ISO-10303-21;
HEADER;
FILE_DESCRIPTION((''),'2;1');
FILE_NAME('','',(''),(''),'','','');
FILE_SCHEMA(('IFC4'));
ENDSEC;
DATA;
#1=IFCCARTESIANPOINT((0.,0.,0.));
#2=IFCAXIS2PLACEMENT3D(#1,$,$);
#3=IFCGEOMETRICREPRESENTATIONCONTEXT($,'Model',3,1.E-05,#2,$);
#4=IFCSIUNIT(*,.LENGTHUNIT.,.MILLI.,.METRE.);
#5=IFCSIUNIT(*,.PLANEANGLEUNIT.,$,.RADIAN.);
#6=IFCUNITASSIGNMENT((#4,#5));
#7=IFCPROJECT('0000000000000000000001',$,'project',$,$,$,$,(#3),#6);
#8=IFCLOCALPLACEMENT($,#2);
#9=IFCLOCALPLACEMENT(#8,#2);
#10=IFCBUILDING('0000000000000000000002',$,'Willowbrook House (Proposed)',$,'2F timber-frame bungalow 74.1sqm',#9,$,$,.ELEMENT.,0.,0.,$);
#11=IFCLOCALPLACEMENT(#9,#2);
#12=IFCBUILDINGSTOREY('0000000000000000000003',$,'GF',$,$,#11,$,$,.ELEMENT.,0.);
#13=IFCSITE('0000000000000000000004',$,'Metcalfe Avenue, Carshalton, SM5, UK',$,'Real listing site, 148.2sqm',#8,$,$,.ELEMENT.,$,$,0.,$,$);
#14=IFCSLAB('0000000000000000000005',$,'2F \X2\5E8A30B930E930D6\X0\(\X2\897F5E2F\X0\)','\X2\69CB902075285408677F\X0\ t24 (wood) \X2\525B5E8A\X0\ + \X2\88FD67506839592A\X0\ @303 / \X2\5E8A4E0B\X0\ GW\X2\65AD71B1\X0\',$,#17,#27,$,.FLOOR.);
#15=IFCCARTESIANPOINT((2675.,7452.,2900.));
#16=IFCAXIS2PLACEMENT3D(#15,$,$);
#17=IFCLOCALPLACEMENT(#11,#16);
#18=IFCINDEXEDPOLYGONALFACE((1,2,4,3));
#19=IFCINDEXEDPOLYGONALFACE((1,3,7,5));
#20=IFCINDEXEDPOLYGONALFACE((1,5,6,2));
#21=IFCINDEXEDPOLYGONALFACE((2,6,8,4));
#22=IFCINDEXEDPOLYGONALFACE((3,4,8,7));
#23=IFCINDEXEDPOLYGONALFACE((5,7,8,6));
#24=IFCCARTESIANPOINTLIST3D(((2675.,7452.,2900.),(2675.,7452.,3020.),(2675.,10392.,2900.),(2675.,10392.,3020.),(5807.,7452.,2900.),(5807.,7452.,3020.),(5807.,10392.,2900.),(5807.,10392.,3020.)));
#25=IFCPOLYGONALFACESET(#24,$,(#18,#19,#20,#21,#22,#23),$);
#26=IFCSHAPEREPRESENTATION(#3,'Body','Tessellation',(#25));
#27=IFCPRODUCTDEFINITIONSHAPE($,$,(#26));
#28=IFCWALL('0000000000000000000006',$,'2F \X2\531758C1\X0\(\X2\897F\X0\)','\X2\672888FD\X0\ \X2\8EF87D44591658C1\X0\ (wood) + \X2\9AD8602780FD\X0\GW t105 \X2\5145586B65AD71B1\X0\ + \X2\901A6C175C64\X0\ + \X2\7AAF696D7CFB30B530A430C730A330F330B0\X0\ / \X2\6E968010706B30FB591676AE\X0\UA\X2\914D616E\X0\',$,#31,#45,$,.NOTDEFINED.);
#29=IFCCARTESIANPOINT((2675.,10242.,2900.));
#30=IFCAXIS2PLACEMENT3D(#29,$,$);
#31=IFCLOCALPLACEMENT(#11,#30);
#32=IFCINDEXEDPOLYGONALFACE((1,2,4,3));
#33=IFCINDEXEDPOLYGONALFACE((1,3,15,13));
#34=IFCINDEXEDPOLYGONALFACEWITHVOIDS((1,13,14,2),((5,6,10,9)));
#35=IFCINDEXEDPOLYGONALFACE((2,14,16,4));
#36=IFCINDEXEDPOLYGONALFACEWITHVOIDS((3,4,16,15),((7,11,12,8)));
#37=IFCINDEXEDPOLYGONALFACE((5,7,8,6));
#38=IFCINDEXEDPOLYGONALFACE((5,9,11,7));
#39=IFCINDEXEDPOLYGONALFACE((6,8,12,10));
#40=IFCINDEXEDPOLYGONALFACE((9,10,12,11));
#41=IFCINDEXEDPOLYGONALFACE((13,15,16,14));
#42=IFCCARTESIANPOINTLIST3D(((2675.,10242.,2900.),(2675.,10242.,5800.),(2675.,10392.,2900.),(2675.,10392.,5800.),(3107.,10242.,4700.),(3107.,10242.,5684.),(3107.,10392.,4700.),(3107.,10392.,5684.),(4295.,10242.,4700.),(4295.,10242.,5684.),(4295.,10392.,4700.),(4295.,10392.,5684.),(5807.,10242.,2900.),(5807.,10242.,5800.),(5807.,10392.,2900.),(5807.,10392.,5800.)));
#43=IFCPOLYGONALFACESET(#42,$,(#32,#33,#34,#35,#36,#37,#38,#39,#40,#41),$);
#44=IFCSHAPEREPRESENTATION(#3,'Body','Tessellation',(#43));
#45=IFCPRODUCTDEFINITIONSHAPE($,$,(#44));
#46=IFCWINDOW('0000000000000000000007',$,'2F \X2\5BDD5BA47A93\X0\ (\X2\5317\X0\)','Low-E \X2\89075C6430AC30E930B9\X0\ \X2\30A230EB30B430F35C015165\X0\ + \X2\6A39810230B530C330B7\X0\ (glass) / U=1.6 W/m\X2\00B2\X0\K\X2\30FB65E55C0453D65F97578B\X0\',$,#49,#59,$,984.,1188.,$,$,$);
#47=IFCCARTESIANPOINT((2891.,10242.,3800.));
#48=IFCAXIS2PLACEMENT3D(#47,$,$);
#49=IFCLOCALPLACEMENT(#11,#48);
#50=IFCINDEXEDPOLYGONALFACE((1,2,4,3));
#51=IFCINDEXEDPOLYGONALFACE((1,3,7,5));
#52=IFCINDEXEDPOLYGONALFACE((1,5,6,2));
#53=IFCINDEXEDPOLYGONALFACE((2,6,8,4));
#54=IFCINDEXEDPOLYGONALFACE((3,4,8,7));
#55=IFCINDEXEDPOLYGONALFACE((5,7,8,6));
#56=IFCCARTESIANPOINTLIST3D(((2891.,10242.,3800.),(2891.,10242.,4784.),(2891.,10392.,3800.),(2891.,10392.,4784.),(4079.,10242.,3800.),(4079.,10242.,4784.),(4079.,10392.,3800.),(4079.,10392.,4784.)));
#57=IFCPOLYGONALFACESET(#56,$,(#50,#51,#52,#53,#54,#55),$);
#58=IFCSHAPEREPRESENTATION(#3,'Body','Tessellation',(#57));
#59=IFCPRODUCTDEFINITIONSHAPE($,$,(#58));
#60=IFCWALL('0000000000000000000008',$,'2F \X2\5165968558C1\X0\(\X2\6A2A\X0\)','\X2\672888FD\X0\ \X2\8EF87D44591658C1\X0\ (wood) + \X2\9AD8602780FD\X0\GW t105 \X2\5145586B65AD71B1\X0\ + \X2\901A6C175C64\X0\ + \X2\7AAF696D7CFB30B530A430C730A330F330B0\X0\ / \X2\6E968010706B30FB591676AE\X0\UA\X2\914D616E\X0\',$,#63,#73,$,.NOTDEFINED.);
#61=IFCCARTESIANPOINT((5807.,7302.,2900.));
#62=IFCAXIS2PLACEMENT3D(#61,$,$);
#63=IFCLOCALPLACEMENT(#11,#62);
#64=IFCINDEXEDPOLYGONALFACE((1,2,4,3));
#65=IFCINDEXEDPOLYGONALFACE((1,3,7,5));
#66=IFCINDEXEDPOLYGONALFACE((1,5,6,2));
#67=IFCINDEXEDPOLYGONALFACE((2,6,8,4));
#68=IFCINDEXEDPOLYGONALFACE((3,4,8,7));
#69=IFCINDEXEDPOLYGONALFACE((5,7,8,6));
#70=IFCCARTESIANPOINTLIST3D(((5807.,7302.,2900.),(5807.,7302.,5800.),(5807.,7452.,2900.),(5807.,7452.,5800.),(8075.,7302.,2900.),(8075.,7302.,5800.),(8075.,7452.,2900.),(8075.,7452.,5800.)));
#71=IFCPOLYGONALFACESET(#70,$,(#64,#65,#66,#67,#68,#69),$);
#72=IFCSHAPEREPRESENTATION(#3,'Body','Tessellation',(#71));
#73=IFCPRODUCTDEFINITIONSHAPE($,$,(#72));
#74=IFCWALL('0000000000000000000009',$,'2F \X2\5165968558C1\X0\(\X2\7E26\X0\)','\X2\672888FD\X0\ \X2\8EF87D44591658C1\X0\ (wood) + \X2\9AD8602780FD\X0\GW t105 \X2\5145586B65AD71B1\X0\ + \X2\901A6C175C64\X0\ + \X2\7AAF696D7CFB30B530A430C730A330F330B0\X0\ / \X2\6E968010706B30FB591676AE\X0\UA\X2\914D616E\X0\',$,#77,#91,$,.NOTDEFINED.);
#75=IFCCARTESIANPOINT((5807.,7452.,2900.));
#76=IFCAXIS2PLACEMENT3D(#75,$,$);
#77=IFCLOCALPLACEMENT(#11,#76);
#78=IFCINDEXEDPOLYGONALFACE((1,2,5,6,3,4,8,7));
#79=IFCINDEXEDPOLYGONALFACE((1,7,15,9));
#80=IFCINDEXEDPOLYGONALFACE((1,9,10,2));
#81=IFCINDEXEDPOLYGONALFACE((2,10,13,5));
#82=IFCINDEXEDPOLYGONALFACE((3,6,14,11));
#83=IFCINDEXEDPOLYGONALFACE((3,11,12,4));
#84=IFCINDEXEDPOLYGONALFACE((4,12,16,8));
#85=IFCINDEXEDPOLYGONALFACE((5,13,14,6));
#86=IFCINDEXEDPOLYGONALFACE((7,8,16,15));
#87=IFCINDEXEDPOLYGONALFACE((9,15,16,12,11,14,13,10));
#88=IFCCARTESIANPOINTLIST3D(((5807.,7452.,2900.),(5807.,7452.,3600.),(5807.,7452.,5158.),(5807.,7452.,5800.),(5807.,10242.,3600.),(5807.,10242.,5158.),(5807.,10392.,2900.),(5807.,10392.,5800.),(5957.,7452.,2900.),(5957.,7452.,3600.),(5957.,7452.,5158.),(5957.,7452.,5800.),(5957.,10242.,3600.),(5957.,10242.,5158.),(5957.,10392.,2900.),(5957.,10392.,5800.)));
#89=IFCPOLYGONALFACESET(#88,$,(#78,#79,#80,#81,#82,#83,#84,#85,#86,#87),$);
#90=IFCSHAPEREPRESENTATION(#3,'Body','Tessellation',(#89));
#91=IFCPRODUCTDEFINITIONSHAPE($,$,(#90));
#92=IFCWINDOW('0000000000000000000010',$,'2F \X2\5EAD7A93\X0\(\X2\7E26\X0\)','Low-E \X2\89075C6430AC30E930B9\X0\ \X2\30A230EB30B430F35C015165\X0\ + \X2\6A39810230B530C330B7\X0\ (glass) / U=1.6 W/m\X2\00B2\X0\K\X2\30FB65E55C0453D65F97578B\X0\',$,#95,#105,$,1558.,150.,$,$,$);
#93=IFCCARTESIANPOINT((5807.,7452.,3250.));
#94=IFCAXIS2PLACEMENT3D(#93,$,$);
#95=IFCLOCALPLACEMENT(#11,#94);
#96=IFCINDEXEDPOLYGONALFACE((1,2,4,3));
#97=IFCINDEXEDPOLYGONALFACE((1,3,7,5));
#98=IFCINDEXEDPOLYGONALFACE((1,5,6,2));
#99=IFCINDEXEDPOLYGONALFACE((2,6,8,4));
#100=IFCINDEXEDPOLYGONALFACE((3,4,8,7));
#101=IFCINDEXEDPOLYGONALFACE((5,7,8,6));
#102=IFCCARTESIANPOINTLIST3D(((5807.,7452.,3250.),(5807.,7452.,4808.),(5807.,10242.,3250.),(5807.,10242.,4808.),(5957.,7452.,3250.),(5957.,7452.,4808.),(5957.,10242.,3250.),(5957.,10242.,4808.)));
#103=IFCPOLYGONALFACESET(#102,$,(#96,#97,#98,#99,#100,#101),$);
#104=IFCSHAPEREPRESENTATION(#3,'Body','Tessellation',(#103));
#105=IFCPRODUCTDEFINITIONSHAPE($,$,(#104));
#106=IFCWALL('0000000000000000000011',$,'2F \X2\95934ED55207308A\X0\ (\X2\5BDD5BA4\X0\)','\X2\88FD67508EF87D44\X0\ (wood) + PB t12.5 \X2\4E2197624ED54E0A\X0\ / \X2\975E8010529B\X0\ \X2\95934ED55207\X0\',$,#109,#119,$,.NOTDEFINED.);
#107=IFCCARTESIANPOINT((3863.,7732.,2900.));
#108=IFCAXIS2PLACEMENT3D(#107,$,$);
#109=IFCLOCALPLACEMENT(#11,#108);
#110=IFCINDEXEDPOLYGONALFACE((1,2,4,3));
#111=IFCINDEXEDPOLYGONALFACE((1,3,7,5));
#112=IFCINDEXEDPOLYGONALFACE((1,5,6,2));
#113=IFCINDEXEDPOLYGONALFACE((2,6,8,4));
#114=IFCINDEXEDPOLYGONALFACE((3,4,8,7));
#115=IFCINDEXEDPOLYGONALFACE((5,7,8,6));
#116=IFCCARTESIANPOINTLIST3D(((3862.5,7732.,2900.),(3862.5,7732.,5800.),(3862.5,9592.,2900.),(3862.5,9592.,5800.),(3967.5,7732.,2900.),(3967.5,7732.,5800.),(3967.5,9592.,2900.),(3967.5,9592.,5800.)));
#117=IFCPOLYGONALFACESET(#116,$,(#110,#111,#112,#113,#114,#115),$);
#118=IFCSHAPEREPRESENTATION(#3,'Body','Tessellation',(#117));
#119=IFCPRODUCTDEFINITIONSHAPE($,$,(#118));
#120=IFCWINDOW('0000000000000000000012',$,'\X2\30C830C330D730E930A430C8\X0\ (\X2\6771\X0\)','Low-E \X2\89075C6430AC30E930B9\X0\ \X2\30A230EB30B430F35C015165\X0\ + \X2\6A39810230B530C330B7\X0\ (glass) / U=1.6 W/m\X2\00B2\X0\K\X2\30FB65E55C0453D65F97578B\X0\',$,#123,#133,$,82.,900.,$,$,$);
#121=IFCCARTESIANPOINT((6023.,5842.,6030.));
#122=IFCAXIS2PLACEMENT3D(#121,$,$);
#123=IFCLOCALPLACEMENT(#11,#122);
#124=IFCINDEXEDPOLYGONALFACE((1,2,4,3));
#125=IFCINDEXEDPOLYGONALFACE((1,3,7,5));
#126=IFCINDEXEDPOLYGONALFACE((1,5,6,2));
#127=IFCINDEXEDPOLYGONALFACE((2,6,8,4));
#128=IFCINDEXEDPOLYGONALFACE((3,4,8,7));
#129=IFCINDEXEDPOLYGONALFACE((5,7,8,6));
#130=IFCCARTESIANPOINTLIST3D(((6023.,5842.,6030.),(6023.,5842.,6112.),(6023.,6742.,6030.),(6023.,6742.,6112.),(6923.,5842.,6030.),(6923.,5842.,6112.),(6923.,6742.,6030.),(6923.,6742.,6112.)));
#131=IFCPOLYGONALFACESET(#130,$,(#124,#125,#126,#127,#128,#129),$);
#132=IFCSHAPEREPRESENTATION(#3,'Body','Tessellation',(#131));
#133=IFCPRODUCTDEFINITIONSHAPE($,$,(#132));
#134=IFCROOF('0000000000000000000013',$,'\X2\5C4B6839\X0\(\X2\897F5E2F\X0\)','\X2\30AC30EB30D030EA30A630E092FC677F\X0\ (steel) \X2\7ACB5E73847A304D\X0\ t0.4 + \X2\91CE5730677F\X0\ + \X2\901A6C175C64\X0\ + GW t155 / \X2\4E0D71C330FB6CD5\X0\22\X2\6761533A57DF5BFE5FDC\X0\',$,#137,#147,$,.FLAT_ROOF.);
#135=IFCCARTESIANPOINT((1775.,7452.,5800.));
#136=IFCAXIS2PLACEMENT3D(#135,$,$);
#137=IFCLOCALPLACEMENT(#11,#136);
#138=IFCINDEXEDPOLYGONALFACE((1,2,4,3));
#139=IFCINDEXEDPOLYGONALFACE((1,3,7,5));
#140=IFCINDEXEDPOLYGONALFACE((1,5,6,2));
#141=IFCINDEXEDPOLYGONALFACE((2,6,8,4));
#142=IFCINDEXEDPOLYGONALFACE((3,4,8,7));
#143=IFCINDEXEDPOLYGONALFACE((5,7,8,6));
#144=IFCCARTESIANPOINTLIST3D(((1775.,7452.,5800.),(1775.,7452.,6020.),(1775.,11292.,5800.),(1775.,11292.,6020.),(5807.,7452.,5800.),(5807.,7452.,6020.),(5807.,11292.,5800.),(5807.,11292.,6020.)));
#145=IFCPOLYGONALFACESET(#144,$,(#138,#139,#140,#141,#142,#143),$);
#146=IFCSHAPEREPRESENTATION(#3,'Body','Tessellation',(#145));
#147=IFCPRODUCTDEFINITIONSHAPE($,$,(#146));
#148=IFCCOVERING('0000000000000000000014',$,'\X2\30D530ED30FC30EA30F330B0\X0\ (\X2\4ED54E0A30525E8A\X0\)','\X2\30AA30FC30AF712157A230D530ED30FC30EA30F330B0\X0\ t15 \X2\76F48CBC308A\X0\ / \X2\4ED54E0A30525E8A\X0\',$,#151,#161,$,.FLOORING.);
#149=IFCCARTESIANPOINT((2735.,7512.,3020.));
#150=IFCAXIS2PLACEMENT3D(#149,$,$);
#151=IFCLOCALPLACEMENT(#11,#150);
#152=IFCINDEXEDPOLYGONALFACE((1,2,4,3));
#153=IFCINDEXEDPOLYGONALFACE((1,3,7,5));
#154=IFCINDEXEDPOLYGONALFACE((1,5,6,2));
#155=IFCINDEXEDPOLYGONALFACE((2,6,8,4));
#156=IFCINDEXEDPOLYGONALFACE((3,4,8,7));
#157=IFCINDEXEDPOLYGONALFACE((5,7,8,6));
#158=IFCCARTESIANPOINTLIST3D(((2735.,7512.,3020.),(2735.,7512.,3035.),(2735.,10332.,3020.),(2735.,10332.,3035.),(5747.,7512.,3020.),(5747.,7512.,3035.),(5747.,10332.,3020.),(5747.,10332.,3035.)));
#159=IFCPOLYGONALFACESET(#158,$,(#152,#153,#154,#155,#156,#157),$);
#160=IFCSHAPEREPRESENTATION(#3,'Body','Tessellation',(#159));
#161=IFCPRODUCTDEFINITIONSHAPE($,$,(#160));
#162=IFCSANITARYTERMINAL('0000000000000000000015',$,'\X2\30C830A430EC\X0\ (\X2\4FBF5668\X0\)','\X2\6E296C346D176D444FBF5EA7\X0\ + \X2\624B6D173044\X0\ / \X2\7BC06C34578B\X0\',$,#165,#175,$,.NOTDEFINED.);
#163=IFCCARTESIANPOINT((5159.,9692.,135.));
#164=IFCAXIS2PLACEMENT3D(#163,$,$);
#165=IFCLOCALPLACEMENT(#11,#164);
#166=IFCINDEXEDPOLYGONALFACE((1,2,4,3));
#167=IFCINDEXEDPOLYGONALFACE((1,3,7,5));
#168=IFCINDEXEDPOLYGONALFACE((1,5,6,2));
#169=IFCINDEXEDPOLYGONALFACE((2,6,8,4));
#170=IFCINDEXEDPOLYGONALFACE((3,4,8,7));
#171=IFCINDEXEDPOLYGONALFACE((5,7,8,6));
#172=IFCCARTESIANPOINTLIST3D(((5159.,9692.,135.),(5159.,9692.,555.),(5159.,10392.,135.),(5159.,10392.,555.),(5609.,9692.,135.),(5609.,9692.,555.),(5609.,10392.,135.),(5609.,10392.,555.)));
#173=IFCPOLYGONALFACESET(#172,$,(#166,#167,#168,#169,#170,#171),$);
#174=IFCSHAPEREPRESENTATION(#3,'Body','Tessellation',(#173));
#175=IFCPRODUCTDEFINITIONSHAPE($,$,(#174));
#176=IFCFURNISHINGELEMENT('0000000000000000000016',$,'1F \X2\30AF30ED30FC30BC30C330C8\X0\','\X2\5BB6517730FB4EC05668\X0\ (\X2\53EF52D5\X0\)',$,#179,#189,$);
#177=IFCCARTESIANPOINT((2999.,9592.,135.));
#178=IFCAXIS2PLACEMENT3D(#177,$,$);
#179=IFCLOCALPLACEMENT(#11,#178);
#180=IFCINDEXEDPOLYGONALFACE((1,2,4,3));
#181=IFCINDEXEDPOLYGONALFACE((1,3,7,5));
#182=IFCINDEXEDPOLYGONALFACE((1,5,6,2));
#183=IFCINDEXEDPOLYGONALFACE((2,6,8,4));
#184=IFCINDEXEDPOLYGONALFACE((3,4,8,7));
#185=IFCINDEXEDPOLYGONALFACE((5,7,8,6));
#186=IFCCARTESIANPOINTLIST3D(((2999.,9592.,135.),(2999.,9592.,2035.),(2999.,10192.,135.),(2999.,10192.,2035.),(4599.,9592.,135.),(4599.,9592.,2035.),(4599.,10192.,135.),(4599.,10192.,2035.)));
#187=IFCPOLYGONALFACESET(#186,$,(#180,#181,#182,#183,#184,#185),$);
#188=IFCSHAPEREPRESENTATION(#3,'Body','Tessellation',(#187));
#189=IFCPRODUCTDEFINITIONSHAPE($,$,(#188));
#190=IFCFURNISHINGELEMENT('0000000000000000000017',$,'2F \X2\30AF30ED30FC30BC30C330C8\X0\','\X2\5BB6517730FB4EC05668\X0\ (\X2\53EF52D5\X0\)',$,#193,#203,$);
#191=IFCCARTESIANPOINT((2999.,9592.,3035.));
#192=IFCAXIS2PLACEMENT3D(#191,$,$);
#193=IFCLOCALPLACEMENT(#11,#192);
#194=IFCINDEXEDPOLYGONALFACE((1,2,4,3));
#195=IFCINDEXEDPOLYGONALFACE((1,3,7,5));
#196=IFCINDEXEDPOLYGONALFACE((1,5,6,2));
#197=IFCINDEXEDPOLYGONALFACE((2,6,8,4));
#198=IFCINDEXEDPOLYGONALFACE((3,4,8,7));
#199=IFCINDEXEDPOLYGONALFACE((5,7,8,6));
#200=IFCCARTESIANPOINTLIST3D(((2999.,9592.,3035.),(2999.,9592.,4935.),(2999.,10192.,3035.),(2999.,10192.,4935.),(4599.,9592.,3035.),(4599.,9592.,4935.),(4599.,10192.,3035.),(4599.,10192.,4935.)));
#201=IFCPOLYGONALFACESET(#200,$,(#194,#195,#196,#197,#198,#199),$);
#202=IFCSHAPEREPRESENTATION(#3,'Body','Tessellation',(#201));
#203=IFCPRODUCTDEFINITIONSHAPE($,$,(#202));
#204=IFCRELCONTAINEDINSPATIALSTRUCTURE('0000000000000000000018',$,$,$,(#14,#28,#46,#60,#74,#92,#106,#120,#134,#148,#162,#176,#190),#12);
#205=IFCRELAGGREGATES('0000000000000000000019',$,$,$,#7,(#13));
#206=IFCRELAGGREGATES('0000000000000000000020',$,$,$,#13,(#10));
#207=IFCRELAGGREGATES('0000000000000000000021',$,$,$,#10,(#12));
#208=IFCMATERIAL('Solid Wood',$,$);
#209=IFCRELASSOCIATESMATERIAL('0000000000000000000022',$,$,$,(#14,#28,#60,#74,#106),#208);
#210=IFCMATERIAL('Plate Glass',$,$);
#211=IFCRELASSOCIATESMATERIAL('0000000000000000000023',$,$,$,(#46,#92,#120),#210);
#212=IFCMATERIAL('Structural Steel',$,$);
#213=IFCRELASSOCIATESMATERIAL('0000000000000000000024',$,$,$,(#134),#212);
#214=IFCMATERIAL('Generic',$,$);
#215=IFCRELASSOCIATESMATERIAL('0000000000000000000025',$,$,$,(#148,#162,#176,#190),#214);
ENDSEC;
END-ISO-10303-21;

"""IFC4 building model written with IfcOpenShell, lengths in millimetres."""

from ifc_helpers import new_model, si_unit, frame, frame_2d, origin, place, context, project, spatial, rectangle, extrude, material, element, fill, save


model = new_model("IFC4")

# Units and contexts
model_context = context("Model", 3, precision=1e-05, world=origin())
ifc_project = project(units=[si_unit("LENGTHUNIT", "METRE", prefix="MILLI"), si_unit("PLANEANGLEUNIT", "RADIAN")], contexts=[model_context])

# Site, building, storey
site_placement = place(None, origin())
site = spatial("IfcSite", under=ifc_project, at=site_placement, Name="Metcalfe Avenue, Carshalton, SM5, UK", ObjectType="Real listing site, 148.2sqm", CompositionType="ELEMENT", RefElevation=0.0)
building_placement = place(site_placement, origin())
building = spatial("IfcBuilding", under=site, at=building_placement, Name="Willowbrook House (Proposed)", ObjectType="2F timber-frame bungalow 74.1sqm", CompositionType="ELEMENT", ElevationOfRefHeight=0.0, ElevationOfTerrain=0.0)
storey_placement = place(building_placement, origin())
storey = spatial("IfcBuildingStorey", under=building, at=storey_placement, Name="GF", CompositionType="ELEMENT", Elevation=0.0)

# Slab
ifc_material_1 = material(Name="Solid Wood")
slab_placement = place(storey_placement, frame((2675.0, 7452.0, 2900.0)))
element("IfcSlab", 1, at=slab_placement, inside=storey, material=ifc_material_1, Name="2F 床スラブ(西帯)", Description="構造用合板 t24 (wood) 剛床 + 製材根太 @303 / 床下 GW断熱", PredefinedType="FLOOR", context=model_context, shape_type="SweptSolid", body=[
    extrude(rectangle(XDim=3132.0, YDim=2940.0, at=frame_2d((1566.0, 1470.0))), frame((2675.0, 7452.0, 2900.0)), (0.0, 0.0, 1.0), 120.0),
])

# Wall, opening, window
wall_1_placement = place(storey_placement, frame((2675.0, 10242.0, 2900.0)))
wall_1 = element("IfcWall", 2, at=wall_1_placement, inside=storey, material=ifc_material_1, Name="2F 北壁(西)", Description="木製 軸組外壁 (wood) + 高性能GW t105 充填断熱 + 通気層 + 窯業系サイディング / 準耐火・外皮UA配慮", PredefinedType="NOTDEFINED", context=model_context, shape_type="SweptSolid", body=[
    extrude(rectangle(XDim=3132.0, YDim=150.0, at=frame_2d((1566.0, 75.0))), frame((2675.0, 10242.0, 2900.0)), (0.0, 0.0, 1.0), 2900.0),
])
opening_1_placement = place(storey_placement, frame((2891.0, 10242.0, 3800.0)))
opening_1 = element("IfcOpeningElement", 3, at=opening_1_placement, cuts=wall_1, PredefinedType="NOTDEFINED", context=model_context, shape_type="SweptSolid", body=[
    extrude(rectangle(XDim=1188.0, YDim=150.0, at=frame_2d((594.0, 75.0))), frame((2891.0, 10242.0, 3800.0)), (0.0, 0.0, 1.0), 984.0),
])
ifc_material_2 = material(Name="Plate Glass")
window_1_placement = place(storey_placement, frame((2891.0, 10242.0, 3800.0)))
window_1 = element("IfcWindow", 4, at=window_1_placement, inside=storey, material=ifc_material_2, Name="2F 寝室窓 (北)", Description="Low-E 複層ガラス アルゴン封入 + 樹脂サッシ (glass) / U=1.6 W/m²K・日射取得型", OverallHeight=984.0, OverallWidth=1188.0, context=model_context, shape_type="SweptSolid", body=[
    extrude(rectangle(XDim=1188.0, YDim=150.0, at=frame_2d((594.0, 75.0))), frame((2891.0, 10242.0, 3800.0)), (0.0, 0.0, 1.0), 984.0),
])
fill(opening_1, window_1)

# Wall
wall_2_placement = place(storey_placement, frame((5807.0, 7302.0, 2900.0)))
element("IfcWall", 5, at=wall_2_placement, inside=storey, material=ifc_material_1, Name="2F 入隅壁(横)", Description="木製 軸組外壁 (wood) + 高性能GW t105 充填断熱 + 通気層 + 窯業系サイディング / 準耐火・外皮UA配慮", PredefinedType="NOTDEFINED", context=model_context, shape_type="SweptSolid", body=[
    extrude(rectangle(XDim=2268.0, YDim=150.0, at=frame_2d((1134.0, 75.0))), frame((5807.0, 7302.0, 2900.0)), (0.0, 0.0, 1.0), 2900.0),
])

# Wall, opening, window
wall_3_placement = place(storey_placement, frame((5807.0, 7452.0, 2900.0)))
wall_3 = element("IfcWall", 6, at=wall_3_placement, inside=storey, material=ifc_material_1, Name="2F 入隅壁(縦)", Description="木製 軸組外壁 (wood) + 高性能GW t105 充填断熱 + 通気層 + 窯業系サイディング / 準耐火・外皮UA配慮", PredefinedType="NOTDEFINED", context=model_context, shape_type="SweptSolid", body=[
    extrude(rectangle(XDim=150.0, YDim=2940.0, at=frame_2d((75.0, 1470.0))), frame((5807.0, 7452.0, 2900.0)), (0.0, 0.0, 1.0), 2900.0),
])
opening_2_placement = place(storey_placement, frame((5807.0, 7452.0, 3250.0)))
opening_2 = element("IfcOpeningElement", 7, at=opening_2_placement, cuts=wall_3, PredefinedType="NOTDEFINED", context=model_context, shape_type="SweptSolid", body=[
    extrude(rectangle(XDim=150.0, YDim=2790.0, at=frame_2d((75.0, 1395.0))), frame((5807.0, 7452.0, 3250.0)), (0.0, 0.0, 1.0), 1558.0),
])
window_2_placement = place(storey_placement, frame((5807.0, 7452.0, 3250.0)))
window_2 = element("IfcWindow", 8, at=window_2_placement, inside=storey, material=ifc_material_2, Name="2F 庭窓(縦)", Description="Low-E 複層ガラス アルゴン封入 + 樹脂サッシ (glass) / U=1.6 W/m²K・日射取得型", OverallHeight=1558.0, OverallWidth=150.0, context=model_context, shape_type="SweptSolid", body=[
    extrude(rectangle(XDim=150.0, YDim=2790.0, at=frame_2d((75.0, 1395.0))), frame((5807.0, 7452.0, 3250.0)), (0.0, 0.0, 1.0), 1558.0),
])
fill(opening_2, window_2)

# Wall
wall_4_placement = place(storey_placement, frame((3863.0, 7732.0, 2900.0)))
element("IfcWall", 9, at=wall_4_placement, inside=storey, material=ifc_material_1, Name="2F 間仕切り (寝室)", Description="製材軸組 (wood) + PB t12.5 両面仕上 / 非耐力 間仕切", PredefinedType="NOTDEFINED", context=model_context, shape_type="SweptSolid", body=[
    extrude(rectangle(XDim=105.0, YDim=1860.0, at=frame_2d((52.0, 930.0))), frame((3863.0, 7732.0, 2900.0)), (0.0, 0.0, 1.0), 2900.0),
])

# Window
window_3_placement = place(storey_placement, frame((6023.0, 5842.0, 6030.0)))
element("IfcWindow", 10, at=window_3_placement, inside=storey, material=ifc_material_2, Name="トップライト (東)", Description="Low-E 複層ガラス アルゴン封入 + 樹脂サッシ (glass) / U=1.6 W/m²K・日射取得型", OverallHeight=82.0, OverallWidth=900.0, context=model_context, shape_type="SweptSolid", body=[
    extrude(rectangle(XDim=900.0, YDim=900.0, at=frame_2d((450.0, 450.0))), frame((6023.0, 5842.0, 6030.0)), (0.0, 0.0, 1.0), 82.0),
])

# Roof
ifc_material_3 = material(Name="Structural Steel")
for number, where, name in (
    (11, (1775.0, 7452.0, 5800.0), "屋根(西帯)"),
):
    element("IfcRoof", number, at=place(storey_placement, frame(where)), inside=storey, material=ifc_material_3, Name=name, Description="ガルバリウム鋼板 (steel) 立平葺き t0.4 + 野地板 + 通気層 + GW t155 / 不燃・法22条区域対応", PredefinedType="FLAT_ROOF", context=model_context, shape_type="SweptSolid", body=[
        extrude(rectangle(XDim=4032.0, YDim=3840.0, at=frame_2d((2016.0, 1920.0))), frame((1775.0, 7452.0, 5800.0)), (0.0, 0.0, 1.0), 220.0),
    ])

# Covering
ifc_material_4 = material(Name="Generic")
covering_placement = place(storey_placement, frame((2735.0, 7512.0, 3020.0)))
element("IfcCovering", 12, at=covering_placement, inside=storey, material=ifc_material_4, Name="フローリング (仕上げ床)", Description="オーク無垢フローリング t15 直貼り / 仕上げ床", PredefinedType="FLOORING", context=model_context, shape_type="SweptSolid", body=[
    extrude(rectangle(XDim=3012.0, YDim=2820.0, at=frame_2d((1506.0, 1410.0))), frame((2735.0, 7512.0, 3020.0)), (0.0, 0.0, 1.0), 15.0),
])

# Sanitary terminal
sanitary_terminal_placement = place(storey_placement, frame((5159.0, 9692.0, 135.0)))
element("IfcSanitaryTerminal", 13, at=sanitary_terminal_placement, inside=storey, material=ifc_material_4, Name="トイレ (便器)", Description="温水洗浄便座 + 手洗い / 節水型", PredefinedType="NOTDEFINED", context=model_context, shape_type="SweptSolid", body=[
    extrude(rectangle(XDim=450.0, YDim=700.0, at=frame_2d((225.0, 350.0))), frame((5159.0, 9692.0, 135.0)), (0.0, 0.0, 1.0), 420.0),
])

# Furnishing elements
furnishing_1_placement = place(storey_placement, frame((2999.0, 9592.0, 135.0)))
element("IfcFurnishingElement", 14, at=furnishing_1_placement, inside=storey, material=ifc_material_4, Name="1F クローゼット", Description="家具・什器 (可動)", context=model_context, shape_type="SweptSolid", body=[
    extrude(rectangle(XDim=1600.0, YDim=600.0, at=frame_2d((800.0, 300.0))), frame((2999.0, 9592.0, 135.0)), (0.0, 0.0, 1.0), 1900.0),
])
furnishing_2_placement = place(storey_placement, frame((2999.0, 9592.0, 3035.0)))
element("IfcFurnishingElement", 15, at=furnishing_2_placement, inside=storey, material=ifc_material_4, Name="2F クローゼット", Description="家具・什器 (可動)", context=model_context, shape_type="SweptSolid", body=[
    extrude(rectangle(XDim=1600.0, YDim=600.0, at=frame_2d((800.0, 300.0))), frame((2999.0, 9592.0, 3035.0)), (0.0, 0.0, 1.0), 1900.0),
])

save(model, "model.ifc")
